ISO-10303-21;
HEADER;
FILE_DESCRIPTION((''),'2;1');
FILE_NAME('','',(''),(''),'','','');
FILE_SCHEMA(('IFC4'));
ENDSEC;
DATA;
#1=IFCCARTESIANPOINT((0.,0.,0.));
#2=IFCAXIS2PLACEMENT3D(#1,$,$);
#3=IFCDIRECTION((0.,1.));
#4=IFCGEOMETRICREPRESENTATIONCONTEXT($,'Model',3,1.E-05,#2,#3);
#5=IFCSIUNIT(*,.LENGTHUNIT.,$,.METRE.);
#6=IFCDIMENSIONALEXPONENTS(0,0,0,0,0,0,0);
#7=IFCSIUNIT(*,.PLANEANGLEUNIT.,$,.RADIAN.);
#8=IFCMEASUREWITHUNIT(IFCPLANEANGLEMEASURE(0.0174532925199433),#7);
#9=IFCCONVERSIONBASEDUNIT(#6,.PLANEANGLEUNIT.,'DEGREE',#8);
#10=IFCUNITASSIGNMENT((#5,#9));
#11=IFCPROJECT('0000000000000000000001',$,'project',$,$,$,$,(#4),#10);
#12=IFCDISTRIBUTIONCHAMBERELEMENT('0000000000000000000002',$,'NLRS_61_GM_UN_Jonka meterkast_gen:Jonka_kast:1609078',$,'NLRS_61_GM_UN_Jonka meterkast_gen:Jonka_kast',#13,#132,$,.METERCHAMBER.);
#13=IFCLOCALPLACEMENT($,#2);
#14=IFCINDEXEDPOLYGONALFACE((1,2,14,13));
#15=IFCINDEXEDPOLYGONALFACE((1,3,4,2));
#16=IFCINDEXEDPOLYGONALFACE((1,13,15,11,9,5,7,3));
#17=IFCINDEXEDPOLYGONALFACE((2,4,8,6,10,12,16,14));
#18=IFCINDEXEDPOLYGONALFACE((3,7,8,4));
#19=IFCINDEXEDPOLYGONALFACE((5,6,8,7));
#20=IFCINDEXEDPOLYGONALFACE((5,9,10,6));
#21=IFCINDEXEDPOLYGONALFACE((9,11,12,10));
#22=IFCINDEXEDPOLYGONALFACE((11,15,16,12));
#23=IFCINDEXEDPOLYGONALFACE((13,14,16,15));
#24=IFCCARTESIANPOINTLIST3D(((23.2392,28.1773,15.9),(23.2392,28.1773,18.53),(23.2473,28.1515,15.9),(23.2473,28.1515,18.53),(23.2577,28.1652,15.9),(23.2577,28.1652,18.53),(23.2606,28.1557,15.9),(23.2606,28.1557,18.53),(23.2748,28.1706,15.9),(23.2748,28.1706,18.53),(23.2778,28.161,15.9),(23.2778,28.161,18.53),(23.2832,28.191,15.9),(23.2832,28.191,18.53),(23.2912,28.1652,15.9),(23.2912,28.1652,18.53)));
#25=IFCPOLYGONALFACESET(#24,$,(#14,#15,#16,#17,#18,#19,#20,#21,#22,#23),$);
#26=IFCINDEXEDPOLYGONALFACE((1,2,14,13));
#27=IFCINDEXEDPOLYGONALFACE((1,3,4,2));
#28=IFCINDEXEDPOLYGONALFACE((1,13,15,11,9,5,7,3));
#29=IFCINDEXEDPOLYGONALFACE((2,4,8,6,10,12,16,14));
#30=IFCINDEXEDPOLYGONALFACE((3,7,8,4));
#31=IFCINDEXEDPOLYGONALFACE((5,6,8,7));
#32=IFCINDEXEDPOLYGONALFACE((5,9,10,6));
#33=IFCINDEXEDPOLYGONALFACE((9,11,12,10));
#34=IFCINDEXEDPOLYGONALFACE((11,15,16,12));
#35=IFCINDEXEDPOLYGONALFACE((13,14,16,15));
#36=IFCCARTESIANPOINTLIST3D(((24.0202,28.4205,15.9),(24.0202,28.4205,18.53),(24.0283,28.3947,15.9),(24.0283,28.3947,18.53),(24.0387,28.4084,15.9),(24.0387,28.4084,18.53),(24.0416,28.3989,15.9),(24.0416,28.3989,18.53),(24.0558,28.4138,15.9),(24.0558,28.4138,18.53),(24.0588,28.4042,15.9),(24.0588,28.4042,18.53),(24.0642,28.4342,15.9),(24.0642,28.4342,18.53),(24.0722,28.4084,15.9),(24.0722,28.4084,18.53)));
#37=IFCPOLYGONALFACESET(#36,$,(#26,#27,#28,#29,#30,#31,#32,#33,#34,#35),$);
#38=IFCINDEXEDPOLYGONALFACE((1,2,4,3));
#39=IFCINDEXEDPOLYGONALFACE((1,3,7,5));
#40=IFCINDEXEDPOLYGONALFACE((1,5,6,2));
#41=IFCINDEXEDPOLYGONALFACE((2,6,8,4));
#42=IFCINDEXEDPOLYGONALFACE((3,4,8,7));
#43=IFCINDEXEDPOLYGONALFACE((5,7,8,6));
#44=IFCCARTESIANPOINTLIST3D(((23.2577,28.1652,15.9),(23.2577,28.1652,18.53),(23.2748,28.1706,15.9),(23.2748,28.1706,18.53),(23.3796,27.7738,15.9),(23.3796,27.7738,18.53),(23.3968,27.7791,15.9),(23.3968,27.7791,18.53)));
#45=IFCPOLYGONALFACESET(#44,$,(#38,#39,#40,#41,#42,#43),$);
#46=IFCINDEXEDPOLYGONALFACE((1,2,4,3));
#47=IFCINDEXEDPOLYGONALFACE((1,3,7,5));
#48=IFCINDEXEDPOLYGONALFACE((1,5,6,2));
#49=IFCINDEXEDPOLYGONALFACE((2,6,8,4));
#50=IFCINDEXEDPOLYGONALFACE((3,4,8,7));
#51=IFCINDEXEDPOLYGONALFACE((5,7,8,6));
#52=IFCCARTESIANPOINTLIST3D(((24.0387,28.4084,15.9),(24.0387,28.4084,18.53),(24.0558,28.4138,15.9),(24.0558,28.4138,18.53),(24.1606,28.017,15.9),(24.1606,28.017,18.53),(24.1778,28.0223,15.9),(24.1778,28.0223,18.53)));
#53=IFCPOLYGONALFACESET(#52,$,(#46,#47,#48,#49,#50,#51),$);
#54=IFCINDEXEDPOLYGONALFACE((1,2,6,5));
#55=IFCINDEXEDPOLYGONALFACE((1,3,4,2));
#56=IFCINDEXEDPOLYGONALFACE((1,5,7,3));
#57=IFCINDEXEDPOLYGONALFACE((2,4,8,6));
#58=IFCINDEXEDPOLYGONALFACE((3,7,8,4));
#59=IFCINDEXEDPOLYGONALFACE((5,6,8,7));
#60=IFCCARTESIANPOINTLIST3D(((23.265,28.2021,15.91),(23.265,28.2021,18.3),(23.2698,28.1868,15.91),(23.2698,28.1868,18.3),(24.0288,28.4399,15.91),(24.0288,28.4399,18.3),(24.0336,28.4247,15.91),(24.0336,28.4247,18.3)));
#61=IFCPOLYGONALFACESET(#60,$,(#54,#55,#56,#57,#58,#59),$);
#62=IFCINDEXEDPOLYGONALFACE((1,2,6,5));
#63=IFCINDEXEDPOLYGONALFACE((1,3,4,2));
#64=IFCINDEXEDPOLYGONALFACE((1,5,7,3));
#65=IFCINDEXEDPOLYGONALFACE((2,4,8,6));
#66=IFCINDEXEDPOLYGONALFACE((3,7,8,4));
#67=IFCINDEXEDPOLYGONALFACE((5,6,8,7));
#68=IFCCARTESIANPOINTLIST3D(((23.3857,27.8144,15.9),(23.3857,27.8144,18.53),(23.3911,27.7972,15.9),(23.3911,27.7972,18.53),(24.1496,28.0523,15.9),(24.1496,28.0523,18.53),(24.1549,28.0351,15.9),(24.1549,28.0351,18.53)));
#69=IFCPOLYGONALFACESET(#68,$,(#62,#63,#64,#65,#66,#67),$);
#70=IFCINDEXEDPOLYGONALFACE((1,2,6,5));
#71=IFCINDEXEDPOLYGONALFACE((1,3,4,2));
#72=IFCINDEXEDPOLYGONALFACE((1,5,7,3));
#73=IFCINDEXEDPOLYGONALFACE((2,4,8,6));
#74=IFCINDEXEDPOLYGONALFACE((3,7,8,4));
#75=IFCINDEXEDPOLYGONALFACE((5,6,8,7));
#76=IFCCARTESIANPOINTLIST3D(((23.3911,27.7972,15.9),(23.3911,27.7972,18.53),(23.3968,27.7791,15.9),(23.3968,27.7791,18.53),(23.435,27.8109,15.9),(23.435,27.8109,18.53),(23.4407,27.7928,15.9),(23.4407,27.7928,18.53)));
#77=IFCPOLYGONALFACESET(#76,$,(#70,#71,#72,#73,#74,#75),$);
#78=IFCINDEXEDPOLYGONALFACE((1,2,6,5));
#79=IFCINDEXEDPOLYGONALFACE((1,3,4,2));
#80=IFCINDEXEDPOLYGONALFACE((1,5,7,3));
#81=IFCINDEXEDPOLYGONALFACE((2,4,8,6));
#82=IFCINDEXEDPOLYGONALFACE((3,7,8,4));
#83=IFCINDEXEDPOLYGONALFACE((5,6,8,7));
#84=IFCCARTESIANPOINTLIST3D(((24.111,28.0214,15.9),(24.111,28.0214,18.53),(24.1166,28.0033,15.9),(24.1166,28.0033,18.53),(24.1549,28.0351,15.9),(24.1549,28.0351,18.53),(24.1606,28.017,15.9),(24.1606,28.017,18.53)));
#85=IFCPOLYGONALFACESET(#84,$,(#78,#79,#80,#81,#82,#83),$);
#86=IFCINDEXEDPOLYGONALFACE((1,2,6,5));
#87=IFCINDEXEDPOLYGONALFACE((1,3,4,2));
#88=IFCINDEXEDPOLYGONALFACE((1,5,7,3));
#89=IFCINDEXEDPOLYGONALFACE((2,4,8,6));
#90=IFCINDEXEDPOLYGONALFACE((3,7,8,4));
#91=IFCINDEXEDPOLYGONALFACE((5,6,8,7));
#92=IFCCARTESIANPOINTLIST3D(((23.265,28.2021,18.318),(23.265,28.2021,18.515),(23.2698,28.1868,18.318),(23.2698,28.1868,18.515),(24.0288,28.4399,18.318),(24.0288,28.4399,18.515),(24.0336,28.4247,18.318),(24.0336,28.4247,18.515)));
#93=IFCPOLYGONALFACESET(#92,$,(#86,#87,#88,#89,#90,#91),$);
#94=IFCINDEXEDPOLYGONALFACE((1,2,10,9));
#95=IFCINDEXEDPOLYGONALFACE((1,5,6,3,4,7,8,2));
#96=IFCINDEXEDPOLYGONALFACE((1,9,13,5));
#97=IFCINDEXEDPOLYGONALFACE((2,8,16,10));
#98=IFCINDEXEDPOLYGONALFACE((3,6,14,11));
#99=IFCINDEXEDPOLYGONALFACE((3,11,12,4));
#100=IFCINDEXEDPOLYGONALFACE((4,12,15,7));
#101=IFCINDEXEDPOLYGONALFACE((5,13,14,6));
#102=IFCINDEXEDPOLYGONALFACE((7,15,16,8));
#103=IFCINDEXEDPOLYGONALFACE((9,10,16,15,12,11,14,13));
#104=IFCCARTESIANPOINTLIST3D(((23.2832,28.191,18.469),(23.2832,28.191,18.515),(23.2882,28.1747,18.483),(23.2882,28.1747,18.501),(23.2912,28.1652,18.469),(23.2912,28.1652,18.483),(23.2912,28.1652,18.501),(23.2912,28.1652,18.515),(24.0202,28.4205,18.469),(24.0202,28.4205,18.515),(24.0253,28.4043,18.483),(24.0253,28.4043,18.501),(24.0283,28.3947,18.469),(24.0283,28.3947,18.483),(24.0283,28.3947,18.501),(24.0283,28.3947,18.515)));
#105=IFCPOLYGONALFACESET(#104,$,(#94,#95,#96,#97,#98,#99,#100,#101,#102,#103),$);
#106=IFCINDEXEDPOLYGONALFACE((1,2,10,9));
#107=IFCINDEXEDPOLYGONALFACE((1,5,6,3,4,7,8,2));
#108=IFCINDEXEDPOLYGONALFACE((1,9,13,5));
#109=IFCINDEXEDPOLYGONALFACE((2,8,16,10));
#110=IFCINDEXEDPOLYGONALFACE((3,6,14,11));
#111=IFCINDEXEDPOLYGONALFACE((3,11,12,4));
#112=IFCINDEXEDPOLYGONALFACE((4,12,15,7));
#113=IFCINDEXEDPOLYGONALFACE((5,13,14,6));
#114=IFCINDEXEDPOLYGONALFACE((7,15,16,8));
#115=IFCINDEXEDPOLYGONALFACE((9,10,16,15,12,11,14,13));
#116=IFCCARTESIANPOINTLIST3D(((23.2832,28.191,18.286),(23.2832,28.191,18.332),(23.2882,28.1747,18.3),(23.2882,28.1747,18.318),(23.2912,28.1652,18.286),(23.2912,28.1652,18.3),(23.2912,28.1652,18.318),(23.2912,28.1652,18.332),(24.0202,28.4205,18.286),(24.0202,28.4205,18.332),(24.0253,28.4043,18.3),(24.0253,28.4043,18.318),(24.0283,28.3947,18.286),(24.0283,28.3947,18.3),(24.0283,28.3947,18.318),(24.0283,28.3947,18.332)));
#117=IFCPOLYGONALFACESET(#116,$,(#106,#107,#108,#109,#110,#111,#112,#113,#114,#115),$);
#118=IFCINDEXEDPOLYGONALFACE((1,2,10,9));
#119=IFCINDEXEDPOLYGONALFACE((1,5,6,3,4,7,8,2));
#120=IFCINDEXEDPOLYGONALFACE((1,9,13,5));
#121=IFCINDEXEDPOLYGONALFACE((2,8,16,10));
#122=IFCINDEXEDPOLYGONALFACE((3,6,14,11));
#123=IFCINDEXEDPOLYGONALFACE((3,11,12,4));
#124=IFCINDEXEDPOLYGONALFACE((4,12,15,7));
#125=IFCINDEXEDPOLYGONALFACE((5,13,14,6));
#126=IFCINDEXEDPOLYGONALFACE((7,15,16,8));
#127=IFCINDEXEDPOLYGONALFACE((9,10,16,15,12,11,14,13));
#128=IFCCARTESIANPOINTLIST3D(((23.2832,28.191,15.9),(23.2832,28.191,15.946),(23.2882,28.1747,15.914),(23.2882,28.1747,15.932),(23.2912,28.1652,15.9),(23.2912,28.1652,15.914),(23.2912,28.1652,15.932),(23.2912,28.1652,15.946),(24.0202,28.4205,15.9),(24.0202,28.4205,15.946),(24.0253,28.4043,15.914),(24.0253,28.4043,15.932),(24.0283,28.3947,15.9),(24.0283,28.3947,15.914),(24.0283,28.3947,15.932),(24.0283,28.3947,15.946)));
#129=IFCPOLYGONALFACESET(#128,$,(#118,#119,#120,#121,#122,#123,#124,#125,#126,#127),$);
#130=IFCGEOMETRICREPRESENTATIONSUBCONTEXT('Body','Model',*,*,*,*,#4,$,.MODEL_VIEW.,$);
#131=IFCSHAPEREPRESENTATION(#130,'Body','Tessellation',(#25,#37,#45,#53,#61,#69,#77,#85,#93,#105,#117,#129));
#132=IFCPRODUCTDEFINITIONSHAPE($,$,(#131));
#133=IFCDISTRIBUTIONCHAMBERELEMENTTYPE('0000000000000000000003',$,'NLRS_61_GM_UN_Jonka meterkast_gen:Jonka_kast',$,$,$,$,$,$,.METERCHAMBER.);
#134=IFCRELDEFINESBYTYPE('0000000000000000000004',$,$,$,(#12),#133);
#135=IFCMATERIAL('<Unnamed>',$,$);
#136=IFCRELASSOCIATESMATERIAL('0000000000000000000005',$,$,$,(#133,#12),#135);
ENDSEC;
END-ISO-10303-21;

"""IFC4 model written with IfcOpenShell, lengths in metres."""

from ifc_helpers import new_model, entity, si_unit, converted_unit, direction, frame, origin, place, context, subcontext, project, indexed_curve, outline, extrude, source, transform, mapped, material, type_object, element, save


model = new_model("IFC4")

# Units and contexts
model_context = context("Model", 3, precision=1e-05, world=origin(), true_north=direction((0.0, 1.0)))
body_context = subcontext(model_context, "Body", "Model", "MODEL_VIEW")
ifc_project = project(units=[si_unit("LENGTHUNIT", "METRE"), converted_unit("PLANEANGLEUNIT", "DEGREE", entity("IfcPlaneAngleMeasure", 0.0174532925199433), si_unit("PLANEANGLEUNIT", "RADIAN"), dimensions=[0, 0, 0, 0, 0, 0, 0])], contexts=[model_context])

# Shared definitions
ifc_material = material(Name="<Unnamed>")
distribution_chamber_element_type = type_object("IfcDistributionChamberElementType", Name="NLRS_61_GM_UN_Jonka meterkast_gen:Jonka_kast", PredefinedType="METERCHAMBER", material=ifc_material)
placement_1 = place(None, frame((13.1348, 11.9886, 0.0), z_axis=(0.0, 0.0, 1.0), x_axis=(0.954771, 0.297342, 0.0)))
placement_2 = place(placement_1, origin())
placement_3 = place(placement_2, frame((0.0, 0.0, 15.9)))

# Distribution chamber element
shared_shape_1 = source(origin(), body_context, "Body", "SweptSolid", [
    extrude(outline(indexed_curve([(-0.023, -0.0093), (-0.009, -0.0093), (-0.009, 0.0007), (0.009, 0.0007), (0.009, -0.0093), (0.023, -0.0093), (0.023, 0.0178), (-0.023, 0.0178), (-0.023, -0.0093)], self_intersect=False)), frame((-0.409, 0.4092, 0.0)), (0.0, 0.0, 1.0), 2.63),
    extrude(outline(indexed_curve([(-0.023, -0.0093), (-0.009, -0.0093), (-0.009, 0.0007), (0.009, 0.0007), (0.009, -0.0093), (0.023, -0.0093), (0.023, 0.0178), (-0.023, 0.0178), (-0.023, -0.0093)], self_intersect=False)), frame((0.409, 0.4092, 0.0)), (0.0, 0.0, 1.0), 2.63),
    extrude(outline(indexed_curve([(-0.009, -0.205), (0.009, -0.205), (0.009, 0.205), (-0.009, 0.205), (-0.009, -0.205)], self_intersect=False)), frame((-0.409, 0.205, 0.0)), (0.0, 0.0, 1.0), 2.63),
    extrude(outline(indexed_curve([(-0.009, -0.205), (0.009, -0.205), (0.009, 0.205), (-0.009, 0.205), (-0.009, -0.205)], self_intersect=False)), frame((0.409, 0.205, 0.0)), (0.0, 0.0, 1.0), 2.63),
    extrude(outline(indexed_curve([(-0.008, -0.4), (0.008, -0.4), (0.008, 0.4), (-0.008, 0.4), (-0.008, -0.4)], self_intersect=False)), frame((0.0, 0.435, 0.01), z_axis=(0.0, 0.0, 1.0), x_axis=(0.0, 1.0, 0.0)), (0.0, 0.0, 1.0), 2.39),
    extrude(outline(indexed_curve([(-0.009, -0.4), (0.009, -0.4), (0.009, 0.4), (-0.009, 0.4), (-0.009, -0.4)], self_intersect=False)), frame((0.0, 0.028, 0.0), z_axis=(0.0, 0.0, 1.0), x_axis=(0.0, 1.0, 0.0)), (0.0, 0.0, 1.0), 2.63),
    extrude(outline(indexed_curve([(-0.0095, -0.023), (0.0095, -0.023), (0.0095, 0.023), (-0.0095, 0.023), (-0.0095, -0.023)], self_intersect=False)), frame((-0.377, 0.0095, 0.0), z_axis=(0.0, 0.0, 1.0), x_axis=(0.0, 1.0, 0.0)), (0.0, 0.0, 1.0), 2.63),
    extrude(outline(indexed_curve([(-0.0095, -0.023), (0.0095, -0.023), (0.0095, 0.023), (-0.0095, 0.023), (-0.0095, -0.023)], self_intersect=False)), frame((0.377, 0.0095, 0.0), z_axis=(0.0, 0.0, 1.0), x_axis=(0.0, 1.0, 0.0)), (0.0, 0.0, 1.0), 2.63),
    extrude(outline(indexed_curve([(-0.008, -0.4), (0.008, -0.4), (0.008, 0.4), (-0.008, 0.4), (-0.008, -0.4)], self_intersect=False)), frame((0.0, 0.435, 2.418), z_axis=(0.0, 0.0, 1.0), x_axis=(0.0, 1.0, 0.0)), (0.0, 0.0, 1.0), 0.197),
    extrude(outline(indexed_curve([(-0.0178, -0.023), (0.0093, -0.023), (0.0093, -0.009), (-0.0007, -0.009), (-0.0007, 0.009), (0.0093, 0.009), (0.0093, 0.023), (-0.0178, 0.023), (-0.0178, -0.023)], self_intersect=False)), frame((-0.386, 0.4092, 2.592), z_axis=(1.0, 0.0, 0.0), x_axis=(0.0, -1.0, 0.0)), (0.0, 0.0, 1.0), 0.772),
    extrude(outline(indexed_curve([(-0.0178, -0.023), (0.0093, -0.023), (0.0093, -0.009), (-0.0007, -0.009), (-0.0007, 0.009), (0.0093, 0.009), (0.0093, 0.023), (-0.0178, 0.023), (-0.0178, -0.023)], self_intersect=False)), frame((-0.386, 0.4092, 2.409), z_axis=(1.0, 0.0, 0.0), x_axis=(0.0, -1.0, 0.0)), (0.0, 0.0, 1.0), 0.772),
    extrude(outline(indexed_curve([(-0.0178, -0.023), (0.0093, -0.023), (0.0093, -0.009), (-0.0007, -0.009), (-0.0007, 0.009), (0.0093, 0.009), (0.0093, 0.023), (-0.0178, 0.023), (-0.0178, -0.023)], self_intersect=False)), frame((-0.386, 0.4092, 0.023), z_axis=(1.0, 0.0, 0.0), x_axis=(0.0, -1.0, 0.0)), (0.0, 0.0, 1.0), 0.772),
])
placement_4 = place(placement_3, origin())
distribution_chamber_element_1_placement = place(placement_4, frame((14.893, 12.025, 0.0)))
element("IfcDistributionChamberElement", 1, at=distribution_chamber_element_1_placement, type_object=distribution_chamber_element_type, material=ifc_material, Name="NLRS_61_GM_UN_Jonka meterkast_gen:Jonka_kast:1609078", ObjectType="NLRS_61_GM_UN_Jonka meterkast_gen:Jonka_kast", PredefinedType="METERCHAMBER", context=body_context, shape_type="MappedRepresentation", body=[
    mapped(shared_shape_1, transform((0.0, 0.0, 0.0), scale=1.0)),
])

save(model, "model.ifc")
